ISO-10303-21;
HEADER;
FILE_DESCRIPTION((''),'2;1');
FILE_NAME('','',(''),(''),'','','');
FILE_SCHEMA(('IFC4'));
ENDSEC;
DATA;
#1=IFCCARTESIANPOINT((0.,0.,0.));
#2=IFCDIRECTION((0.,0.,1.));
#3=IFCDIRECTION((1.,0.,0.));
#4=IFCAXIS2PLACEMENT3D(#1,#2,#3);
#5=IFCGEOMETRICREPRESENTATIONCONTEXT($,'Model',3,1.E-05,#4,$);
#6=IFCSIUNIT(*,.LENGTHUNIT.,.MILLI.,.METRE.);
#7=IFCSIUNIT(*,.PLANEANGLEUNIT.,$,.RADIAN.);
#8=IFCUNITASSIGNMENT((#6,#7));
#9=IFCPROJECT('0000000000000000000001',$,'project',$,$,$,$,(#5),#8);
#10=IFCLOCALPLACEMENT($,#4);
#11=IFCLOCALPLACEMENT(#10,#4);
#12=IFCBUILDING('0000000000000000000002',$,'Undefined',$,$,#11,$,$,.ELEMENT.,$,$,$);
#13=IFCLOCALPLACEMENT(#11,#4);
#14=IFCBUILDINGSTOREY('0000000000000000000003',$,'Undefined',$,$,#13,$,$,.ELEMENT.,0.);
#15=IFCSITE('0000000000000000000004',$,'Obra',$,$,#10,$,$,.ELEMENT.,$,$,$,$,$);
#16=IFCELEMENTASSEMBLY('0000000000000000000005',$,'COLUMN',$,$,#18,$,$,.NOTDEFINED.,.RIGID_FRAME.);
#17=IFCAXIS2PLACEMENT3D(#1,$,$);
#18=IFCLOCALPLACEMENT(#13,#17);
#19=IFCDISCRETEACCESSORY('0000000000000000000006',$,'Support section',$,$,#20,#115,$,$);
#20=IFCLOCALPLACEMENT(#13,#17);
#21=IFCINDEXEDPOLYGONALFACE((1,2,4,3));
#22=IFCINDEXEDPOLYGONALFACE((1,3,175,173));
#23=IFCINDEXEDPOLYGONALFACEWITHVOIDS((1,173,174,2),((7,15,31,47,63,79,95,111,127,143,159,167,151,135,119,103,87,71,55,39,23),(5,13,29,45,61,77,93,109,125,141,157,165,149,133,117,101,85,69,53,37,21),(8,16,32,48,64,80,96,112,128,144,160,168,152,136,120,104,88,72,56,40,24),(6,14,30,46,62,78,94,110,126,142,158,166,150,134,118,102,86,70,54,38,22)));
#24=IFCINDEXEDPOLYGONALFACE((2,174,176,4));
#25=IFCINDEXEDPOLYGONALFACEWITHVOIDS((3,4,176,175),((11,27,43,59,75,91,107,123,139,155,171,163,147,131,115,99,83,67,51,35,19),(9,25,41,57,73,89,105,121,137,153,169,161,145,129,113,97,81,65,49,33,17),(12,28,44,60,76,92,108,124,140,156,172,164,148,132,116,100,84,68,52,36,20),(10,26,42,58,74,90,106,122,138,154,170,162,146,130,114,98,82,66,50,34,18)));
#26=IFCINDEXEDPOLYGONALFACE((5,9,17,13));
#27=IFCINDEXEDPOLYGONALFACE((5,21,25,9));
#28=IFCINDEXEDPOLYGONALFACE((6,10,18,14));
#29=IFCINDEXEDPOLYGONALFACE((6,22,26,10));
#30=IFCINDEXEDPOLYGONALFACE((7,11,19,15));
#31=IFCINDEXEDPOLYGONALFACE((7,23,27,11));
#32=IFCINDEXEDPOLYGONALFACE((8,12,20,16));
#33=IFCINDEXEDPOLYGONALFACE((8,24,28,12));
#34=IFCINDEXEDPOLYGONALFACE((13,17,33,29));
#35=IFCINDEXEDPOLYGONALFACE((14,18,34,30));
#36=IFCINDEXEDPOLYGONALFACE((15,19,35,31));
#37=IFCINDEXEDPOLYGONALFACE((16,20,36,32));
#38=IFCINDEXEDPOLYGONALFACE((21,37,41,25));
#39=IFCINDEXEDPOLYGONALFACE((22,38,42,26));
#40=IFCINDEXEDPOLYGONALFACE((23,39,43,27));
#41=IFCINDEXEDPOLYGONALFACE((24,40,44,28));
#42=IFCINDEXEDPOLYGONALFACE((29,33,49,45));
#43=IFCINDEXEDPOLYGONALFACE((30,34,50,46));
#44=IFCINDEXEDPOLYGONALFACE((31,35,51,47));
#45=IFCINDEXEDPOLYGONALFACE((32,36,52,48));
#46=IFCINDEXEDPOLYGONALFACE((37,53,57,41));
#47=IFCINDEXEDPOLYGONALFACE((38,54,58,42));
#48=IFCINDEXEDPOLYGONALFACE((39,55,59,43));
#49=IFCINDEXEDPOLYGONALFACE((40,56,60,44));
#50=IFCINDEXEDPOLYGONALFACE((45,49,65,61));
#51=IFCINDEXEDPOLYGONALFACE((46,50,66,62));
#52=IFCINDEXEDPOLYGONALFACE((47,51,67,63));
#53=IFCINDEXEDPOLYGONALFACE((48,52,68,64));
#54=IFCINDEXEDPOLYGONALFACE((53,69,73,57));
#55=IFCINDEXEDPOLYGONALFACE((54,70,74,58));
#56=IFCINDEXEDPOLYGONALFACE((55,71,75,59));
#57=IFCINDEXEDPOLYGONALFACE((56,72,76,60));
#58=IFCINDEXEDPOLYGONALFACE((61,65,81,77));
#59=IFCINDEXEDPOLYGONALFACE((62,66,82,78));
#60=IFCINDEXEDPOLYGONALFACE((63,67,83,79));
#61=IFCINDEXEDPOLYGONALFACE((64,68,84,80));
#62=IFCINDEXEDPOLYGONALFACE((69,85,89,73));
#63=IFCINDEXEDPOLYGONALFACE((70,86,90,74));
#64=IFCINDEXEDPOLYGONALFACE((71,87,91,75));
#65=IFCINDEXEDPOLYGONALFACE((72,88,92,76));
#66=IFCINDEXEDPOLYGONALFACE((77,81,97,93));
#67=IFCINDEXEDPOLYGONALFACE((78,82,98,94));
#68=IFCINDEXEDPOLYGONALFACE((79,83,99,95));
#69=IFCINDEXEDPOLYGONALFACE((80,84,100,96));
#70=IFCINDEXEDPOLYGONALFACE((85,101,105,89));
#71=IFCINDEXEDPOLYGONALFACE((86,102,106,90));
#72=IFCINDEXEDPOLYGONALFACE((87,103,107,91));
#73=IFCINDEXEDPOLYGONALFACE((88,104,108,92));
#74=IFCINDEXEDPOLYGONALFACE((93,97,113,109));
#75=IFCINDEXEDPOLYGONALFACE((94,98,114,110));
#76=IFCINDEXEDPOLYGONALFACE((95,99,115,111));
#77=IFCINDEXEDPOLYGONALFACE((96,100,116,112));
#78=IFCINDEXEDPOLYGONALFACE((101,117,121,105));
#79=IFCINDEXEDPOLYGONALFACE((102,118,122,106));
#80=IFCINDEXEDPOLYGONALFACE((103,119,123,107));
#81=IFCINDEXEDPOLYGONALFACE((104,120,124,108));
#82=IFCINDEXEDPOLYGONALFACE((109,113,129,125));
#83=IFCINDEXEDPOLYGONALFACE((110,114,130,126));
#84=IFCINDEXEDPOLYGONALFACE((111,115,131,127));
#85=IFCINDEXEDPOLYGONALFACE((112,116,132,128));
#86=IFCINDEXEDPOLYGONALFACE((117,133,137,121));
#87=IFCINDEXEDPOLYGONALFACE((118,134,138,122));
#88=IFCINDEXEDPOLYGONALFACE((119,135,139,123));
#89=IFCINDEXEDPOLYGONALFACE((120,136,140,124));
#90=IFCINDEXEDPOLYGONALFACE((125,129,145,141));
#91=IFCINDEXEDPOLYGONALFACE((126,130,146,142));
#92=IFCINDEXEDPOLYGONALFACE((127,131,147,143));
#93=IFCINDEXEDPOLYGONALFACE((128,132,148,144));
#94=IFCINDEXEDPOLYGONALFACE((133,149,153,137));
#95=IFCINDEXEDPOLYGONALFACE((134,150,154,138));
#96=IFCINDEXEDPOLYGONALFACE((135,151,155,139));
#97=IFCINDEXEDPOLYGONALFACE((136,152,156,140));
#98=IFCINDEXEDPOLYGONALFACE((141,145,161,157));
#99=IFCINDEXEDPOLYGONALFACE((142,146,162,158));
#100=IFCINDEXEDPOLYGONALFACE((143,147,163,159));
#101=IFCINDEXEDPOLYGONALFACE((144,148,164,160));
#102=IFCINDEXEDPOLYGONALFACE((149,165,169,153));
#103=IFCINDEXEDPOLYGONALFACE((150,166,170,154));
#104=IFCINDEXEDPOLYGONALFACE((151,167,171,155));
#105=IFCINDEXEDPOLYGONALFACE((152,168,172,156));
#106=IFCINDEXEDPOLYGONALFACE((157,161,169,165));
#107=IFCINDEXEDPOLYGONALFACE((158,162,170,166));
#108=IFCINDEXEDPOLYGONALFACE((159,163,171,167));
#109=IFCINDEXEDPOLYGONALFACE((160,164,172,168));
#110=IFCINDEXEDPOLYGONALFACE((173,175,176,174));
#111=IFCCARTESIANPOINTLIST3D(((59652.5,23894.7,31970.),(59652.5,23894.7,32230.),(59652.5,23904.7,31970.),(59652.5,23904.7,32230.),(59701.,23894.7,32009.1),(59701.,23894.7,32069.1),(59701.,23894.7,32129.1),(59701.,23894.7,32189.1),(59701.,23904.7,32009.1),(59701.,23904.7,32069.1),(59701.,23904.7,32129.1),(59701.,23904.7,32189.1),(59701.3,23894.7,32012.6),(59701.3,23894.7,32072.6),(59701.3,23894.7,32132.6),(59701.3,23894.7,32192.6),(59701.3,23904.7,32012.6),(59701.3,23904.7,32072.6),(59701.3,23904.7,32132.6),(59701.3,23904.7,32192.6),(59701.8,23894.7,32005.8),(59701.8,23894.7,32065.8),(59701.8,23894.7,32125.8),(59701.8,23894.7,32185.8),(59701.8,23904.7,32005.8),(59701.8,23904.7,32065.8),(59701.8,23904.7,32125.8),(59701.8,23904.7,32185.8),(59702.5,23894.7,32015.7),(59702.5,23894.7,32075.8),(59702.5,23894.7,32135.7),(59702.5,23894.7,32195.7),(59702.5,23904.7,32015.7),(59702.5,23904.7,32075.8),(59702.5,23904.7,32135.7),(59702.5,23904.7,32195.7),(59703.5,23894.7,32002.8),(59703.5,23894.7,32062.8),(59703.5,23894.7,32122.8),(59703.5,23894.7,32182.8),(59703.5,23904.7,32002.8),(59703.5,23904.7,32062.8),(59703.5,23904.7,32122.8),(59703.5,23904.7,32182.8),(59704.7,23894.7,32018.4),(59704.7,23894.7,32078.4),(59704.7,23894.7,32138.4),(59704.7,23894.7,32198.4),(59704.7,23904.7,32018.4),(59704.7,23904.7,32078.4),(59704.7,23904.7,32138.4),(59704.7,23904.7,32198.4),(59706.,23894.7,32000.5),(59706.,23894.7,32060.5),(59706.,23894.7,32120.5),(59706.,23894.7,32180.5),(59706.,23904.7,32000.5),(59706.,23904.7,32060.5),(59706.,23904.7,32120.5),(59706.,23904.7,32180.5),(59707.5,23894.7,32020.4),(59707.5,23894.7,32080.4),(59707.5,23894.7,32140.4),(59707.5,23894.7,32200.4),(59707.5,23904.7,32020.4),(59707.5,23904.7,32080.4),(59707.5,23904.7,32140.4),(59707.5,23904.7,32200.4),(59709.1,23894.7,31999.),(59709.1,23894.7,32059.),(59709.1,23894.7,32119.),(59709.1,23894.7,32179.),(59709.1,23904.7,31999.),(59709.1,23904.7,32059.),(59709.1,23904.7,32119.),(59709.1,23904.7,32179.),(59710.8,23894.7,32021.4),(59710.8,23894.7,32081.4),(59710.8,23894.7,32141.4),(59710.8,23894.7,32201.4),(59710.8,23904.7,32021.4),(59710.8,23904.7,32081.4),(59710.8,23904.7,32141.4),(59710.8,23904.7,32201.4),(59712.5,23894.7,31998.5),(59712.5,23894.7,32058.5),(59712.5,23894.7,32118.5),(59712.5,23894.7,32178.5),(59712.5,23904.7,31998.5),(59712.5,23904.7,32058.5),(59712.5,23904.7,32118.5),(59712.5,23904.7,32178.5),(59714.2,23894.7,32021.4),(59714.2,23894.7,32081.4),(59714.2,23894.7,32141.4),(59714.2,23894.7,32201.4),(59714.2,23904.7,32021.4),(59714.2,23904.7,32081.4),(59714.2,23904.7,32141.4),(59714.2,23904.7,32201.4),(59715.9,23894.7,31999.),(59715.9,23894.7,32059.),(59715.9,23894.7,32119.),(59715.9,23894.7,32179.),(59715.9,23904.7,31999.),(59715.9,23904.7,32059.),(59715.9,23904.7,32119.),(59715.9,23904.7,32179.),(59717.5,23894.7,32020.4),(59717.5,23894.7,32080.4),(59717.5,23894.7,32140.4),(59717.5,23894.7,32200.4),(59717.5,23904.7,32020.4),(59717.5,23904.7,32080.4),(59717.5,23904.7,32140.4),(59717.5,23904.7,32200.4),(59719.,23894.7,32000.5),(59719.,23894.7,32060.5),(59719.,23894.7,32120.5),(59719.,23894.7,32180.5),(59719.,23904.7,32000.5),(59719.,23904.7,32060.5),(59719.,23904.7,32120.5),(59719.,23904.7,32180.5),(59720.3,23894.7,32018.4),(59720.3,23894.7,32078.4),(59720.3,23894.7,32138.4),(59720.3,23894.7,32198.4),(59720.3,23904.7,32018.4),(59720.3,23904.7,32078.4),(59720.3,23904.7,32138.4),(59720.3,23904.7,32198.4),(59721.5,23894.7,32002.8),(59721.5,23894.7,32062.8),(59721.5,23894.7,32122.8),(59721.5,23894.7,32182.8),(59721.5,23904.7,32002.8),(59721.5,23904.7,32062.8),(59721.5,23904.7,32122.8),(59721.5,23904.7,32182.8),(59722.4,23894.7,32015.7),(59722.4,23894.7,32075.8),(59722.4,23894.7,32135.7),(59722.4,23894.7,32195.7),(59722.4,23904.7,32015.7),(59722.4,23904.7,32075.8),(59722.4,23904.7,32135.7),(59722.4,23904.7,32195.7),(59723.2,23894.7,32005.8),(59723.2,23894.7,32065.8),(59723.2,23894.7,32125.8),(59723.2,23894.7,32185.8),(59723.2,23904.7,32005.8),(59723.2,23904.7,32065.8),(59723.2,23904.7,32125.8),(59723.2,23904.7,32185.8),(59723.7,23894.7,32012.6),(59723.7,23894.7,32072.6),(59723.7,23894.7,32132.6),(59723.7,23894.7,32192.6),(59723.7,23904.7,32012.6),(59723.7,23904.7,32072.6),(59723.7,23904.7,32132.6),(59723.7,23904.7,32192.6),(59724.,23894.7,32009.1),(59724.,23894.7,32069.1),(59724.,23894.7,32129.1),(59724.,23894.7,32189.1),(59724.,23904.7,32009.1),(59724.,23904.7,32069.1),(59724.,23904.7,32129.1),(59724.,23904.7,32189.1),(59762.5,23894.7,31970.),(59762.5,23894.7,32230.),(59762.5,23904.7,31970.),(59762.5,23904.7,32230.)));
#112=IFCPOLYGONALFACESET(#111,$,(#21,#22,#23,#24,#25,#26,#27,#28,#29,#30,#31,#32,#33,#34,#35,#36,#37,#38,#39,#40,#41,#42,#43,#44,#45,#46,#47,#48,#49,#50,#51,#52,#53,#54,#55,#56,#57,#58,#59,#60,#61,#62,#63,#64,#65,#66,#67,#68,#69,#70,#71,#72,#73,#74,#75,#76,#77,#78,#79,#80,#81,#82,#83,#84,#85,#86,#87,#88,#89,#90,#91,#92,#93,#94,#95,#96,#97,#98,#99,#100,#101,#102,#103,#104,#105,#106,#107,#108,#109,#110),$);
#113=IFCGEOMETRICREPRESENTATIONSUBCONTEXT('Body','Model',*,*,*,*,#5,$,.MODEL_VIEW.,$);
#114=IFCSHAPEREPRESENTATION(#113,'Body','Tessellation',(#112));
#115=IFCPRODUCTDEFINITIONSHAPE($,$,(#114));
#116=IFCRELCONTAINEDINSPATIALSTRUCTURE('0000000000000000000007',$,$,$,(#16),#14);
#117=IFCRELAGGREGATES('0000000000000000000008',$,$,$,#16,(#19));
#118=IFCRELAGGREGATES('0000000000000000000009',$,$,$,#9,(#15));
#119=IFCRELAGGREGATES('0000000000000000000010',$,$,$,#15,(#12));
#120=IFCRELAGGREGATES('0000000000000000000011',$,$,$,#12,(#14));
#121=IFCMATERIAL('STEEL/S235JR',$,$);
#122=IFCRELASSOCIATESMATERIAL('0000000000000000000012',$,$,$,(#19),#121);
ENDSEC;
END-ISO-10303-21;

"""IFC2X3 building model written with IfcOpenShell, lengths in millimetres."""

from ifc_helpers import new_model, si_unit, frame, origin_with_axes, origin_2d_with_axis, place, context, subcontext, project, spatial, rectangle, circle, extrude, source, transform, mapped, material, element, aggregate, save


model = new_model("IFC2X3")

# Units and contexts
model_context = context("Model", 3, precision=1e-05, world=origin_with_axes())
body_context = subcontext(model_context, "Body", "Model", "MODEL_VIEW")
ifc_project = project(units=[si_unit("LENGTHUNIT", "METRE", prefix="MILLI"), si_unit("PLANEANGLEUNIT", "RADIAN")], contexts=[model_context])

# Site, building, storey
site_placement = place(None, origin_with_axes())
site = spatial("IfcSite", under=ifc_project, at=site_placement, Name="Obra", CompositionType="ELEMENT")
building_placement = place(site_placement, origin_with_axes())
building = spatial("IfcBuilding", under=site, at=building_placement, Name="Undefined", CompositionType="ELEMENT")
storey_placement = place(building_placement, origin_with_axes())
storey = spatial("IfcBuildingStorey", under=building, at=storey_placement, Name="Undefined", CompositionType="ELEMENT", Elevation=0.0)

# Element assembly
ifc_material_1 = material(Name="STEEL/S235JR")
assembly_1_placement = place(storey_placement, origin_with_axes())
assembly_1 = element("IfcElementAssembly", 1, at=assembly_1_placement, inside=storey, Name="COLUMN", AssemblyPlace="NOTDEFINED", PredefinedType="RIGID_FRAME")

# Discrete accessory, opening
shared_shape_1 = source(origin_with_axes(), body_context, "Body", "SweptSolid", [
    extrude(circle(Radius=11.5, at=origin_2d_with_axis()), frame((0.0, -14.4, 0.0), z_axis=(0.0, 1.0, 0.0), x_axis=(1.0, 0.0, 0.0)), (0.0, 0.0, 1.0), 10.2),
])
discrete_accessory_1_placement = place(assembly_1_placement, frame((59707.5, 23899.7, 31970.0), z_axis=(0.0, 0.0, 1.0), x_axis=(-1.0, 0.0, 0.0)))
discrete_accessory_1 = element("IfcDiscreteAccessory", 2, at=discrete_accessory_1_placement, material=ifc_material_1, Name="Support section", context=body_context, shape_type="SweptSolid", body=[
    extrude(rectangle(XDim=10.0, YDim=110.0, at=origin_2d_with_axis()), frame((0.0, 0.0, 260.0), z_axis=(0.0, 0.0, -1.0), x_axis=(0.0, 1.0, 0.0)), (0.0, 0.0, 1.0), 260.0),
])
opening_1_placement = place(assembly_1_placement, frame((59662.5, 23909.0, 32300.0), z_axis=(1.0, 0.0, 0.0), x_axis=(0.0, 0.0, -1.0)))
element("IfcOpeningElement", 3, at=opening_1_placement, cuts=discrete_accessory_1, ObjectType="Opening", context=body_context, shape_type="MappedRepresentation", body=[
    mapped(shared_shape_1, transform((110.0, 0.0, 50.0))),
    mapped(shared_shape_1, transform((170.0, 0.0, 50.0))),
    mapped(shared_shape_1, transform((230.0, 0.0, 50.0))),
    mapped(shared_shape_1, transform((290.0, 0.0, 50.0))),
])
aggregate(assembly_1, [discrete_accessory_1])

save(model, "model.ifc")
